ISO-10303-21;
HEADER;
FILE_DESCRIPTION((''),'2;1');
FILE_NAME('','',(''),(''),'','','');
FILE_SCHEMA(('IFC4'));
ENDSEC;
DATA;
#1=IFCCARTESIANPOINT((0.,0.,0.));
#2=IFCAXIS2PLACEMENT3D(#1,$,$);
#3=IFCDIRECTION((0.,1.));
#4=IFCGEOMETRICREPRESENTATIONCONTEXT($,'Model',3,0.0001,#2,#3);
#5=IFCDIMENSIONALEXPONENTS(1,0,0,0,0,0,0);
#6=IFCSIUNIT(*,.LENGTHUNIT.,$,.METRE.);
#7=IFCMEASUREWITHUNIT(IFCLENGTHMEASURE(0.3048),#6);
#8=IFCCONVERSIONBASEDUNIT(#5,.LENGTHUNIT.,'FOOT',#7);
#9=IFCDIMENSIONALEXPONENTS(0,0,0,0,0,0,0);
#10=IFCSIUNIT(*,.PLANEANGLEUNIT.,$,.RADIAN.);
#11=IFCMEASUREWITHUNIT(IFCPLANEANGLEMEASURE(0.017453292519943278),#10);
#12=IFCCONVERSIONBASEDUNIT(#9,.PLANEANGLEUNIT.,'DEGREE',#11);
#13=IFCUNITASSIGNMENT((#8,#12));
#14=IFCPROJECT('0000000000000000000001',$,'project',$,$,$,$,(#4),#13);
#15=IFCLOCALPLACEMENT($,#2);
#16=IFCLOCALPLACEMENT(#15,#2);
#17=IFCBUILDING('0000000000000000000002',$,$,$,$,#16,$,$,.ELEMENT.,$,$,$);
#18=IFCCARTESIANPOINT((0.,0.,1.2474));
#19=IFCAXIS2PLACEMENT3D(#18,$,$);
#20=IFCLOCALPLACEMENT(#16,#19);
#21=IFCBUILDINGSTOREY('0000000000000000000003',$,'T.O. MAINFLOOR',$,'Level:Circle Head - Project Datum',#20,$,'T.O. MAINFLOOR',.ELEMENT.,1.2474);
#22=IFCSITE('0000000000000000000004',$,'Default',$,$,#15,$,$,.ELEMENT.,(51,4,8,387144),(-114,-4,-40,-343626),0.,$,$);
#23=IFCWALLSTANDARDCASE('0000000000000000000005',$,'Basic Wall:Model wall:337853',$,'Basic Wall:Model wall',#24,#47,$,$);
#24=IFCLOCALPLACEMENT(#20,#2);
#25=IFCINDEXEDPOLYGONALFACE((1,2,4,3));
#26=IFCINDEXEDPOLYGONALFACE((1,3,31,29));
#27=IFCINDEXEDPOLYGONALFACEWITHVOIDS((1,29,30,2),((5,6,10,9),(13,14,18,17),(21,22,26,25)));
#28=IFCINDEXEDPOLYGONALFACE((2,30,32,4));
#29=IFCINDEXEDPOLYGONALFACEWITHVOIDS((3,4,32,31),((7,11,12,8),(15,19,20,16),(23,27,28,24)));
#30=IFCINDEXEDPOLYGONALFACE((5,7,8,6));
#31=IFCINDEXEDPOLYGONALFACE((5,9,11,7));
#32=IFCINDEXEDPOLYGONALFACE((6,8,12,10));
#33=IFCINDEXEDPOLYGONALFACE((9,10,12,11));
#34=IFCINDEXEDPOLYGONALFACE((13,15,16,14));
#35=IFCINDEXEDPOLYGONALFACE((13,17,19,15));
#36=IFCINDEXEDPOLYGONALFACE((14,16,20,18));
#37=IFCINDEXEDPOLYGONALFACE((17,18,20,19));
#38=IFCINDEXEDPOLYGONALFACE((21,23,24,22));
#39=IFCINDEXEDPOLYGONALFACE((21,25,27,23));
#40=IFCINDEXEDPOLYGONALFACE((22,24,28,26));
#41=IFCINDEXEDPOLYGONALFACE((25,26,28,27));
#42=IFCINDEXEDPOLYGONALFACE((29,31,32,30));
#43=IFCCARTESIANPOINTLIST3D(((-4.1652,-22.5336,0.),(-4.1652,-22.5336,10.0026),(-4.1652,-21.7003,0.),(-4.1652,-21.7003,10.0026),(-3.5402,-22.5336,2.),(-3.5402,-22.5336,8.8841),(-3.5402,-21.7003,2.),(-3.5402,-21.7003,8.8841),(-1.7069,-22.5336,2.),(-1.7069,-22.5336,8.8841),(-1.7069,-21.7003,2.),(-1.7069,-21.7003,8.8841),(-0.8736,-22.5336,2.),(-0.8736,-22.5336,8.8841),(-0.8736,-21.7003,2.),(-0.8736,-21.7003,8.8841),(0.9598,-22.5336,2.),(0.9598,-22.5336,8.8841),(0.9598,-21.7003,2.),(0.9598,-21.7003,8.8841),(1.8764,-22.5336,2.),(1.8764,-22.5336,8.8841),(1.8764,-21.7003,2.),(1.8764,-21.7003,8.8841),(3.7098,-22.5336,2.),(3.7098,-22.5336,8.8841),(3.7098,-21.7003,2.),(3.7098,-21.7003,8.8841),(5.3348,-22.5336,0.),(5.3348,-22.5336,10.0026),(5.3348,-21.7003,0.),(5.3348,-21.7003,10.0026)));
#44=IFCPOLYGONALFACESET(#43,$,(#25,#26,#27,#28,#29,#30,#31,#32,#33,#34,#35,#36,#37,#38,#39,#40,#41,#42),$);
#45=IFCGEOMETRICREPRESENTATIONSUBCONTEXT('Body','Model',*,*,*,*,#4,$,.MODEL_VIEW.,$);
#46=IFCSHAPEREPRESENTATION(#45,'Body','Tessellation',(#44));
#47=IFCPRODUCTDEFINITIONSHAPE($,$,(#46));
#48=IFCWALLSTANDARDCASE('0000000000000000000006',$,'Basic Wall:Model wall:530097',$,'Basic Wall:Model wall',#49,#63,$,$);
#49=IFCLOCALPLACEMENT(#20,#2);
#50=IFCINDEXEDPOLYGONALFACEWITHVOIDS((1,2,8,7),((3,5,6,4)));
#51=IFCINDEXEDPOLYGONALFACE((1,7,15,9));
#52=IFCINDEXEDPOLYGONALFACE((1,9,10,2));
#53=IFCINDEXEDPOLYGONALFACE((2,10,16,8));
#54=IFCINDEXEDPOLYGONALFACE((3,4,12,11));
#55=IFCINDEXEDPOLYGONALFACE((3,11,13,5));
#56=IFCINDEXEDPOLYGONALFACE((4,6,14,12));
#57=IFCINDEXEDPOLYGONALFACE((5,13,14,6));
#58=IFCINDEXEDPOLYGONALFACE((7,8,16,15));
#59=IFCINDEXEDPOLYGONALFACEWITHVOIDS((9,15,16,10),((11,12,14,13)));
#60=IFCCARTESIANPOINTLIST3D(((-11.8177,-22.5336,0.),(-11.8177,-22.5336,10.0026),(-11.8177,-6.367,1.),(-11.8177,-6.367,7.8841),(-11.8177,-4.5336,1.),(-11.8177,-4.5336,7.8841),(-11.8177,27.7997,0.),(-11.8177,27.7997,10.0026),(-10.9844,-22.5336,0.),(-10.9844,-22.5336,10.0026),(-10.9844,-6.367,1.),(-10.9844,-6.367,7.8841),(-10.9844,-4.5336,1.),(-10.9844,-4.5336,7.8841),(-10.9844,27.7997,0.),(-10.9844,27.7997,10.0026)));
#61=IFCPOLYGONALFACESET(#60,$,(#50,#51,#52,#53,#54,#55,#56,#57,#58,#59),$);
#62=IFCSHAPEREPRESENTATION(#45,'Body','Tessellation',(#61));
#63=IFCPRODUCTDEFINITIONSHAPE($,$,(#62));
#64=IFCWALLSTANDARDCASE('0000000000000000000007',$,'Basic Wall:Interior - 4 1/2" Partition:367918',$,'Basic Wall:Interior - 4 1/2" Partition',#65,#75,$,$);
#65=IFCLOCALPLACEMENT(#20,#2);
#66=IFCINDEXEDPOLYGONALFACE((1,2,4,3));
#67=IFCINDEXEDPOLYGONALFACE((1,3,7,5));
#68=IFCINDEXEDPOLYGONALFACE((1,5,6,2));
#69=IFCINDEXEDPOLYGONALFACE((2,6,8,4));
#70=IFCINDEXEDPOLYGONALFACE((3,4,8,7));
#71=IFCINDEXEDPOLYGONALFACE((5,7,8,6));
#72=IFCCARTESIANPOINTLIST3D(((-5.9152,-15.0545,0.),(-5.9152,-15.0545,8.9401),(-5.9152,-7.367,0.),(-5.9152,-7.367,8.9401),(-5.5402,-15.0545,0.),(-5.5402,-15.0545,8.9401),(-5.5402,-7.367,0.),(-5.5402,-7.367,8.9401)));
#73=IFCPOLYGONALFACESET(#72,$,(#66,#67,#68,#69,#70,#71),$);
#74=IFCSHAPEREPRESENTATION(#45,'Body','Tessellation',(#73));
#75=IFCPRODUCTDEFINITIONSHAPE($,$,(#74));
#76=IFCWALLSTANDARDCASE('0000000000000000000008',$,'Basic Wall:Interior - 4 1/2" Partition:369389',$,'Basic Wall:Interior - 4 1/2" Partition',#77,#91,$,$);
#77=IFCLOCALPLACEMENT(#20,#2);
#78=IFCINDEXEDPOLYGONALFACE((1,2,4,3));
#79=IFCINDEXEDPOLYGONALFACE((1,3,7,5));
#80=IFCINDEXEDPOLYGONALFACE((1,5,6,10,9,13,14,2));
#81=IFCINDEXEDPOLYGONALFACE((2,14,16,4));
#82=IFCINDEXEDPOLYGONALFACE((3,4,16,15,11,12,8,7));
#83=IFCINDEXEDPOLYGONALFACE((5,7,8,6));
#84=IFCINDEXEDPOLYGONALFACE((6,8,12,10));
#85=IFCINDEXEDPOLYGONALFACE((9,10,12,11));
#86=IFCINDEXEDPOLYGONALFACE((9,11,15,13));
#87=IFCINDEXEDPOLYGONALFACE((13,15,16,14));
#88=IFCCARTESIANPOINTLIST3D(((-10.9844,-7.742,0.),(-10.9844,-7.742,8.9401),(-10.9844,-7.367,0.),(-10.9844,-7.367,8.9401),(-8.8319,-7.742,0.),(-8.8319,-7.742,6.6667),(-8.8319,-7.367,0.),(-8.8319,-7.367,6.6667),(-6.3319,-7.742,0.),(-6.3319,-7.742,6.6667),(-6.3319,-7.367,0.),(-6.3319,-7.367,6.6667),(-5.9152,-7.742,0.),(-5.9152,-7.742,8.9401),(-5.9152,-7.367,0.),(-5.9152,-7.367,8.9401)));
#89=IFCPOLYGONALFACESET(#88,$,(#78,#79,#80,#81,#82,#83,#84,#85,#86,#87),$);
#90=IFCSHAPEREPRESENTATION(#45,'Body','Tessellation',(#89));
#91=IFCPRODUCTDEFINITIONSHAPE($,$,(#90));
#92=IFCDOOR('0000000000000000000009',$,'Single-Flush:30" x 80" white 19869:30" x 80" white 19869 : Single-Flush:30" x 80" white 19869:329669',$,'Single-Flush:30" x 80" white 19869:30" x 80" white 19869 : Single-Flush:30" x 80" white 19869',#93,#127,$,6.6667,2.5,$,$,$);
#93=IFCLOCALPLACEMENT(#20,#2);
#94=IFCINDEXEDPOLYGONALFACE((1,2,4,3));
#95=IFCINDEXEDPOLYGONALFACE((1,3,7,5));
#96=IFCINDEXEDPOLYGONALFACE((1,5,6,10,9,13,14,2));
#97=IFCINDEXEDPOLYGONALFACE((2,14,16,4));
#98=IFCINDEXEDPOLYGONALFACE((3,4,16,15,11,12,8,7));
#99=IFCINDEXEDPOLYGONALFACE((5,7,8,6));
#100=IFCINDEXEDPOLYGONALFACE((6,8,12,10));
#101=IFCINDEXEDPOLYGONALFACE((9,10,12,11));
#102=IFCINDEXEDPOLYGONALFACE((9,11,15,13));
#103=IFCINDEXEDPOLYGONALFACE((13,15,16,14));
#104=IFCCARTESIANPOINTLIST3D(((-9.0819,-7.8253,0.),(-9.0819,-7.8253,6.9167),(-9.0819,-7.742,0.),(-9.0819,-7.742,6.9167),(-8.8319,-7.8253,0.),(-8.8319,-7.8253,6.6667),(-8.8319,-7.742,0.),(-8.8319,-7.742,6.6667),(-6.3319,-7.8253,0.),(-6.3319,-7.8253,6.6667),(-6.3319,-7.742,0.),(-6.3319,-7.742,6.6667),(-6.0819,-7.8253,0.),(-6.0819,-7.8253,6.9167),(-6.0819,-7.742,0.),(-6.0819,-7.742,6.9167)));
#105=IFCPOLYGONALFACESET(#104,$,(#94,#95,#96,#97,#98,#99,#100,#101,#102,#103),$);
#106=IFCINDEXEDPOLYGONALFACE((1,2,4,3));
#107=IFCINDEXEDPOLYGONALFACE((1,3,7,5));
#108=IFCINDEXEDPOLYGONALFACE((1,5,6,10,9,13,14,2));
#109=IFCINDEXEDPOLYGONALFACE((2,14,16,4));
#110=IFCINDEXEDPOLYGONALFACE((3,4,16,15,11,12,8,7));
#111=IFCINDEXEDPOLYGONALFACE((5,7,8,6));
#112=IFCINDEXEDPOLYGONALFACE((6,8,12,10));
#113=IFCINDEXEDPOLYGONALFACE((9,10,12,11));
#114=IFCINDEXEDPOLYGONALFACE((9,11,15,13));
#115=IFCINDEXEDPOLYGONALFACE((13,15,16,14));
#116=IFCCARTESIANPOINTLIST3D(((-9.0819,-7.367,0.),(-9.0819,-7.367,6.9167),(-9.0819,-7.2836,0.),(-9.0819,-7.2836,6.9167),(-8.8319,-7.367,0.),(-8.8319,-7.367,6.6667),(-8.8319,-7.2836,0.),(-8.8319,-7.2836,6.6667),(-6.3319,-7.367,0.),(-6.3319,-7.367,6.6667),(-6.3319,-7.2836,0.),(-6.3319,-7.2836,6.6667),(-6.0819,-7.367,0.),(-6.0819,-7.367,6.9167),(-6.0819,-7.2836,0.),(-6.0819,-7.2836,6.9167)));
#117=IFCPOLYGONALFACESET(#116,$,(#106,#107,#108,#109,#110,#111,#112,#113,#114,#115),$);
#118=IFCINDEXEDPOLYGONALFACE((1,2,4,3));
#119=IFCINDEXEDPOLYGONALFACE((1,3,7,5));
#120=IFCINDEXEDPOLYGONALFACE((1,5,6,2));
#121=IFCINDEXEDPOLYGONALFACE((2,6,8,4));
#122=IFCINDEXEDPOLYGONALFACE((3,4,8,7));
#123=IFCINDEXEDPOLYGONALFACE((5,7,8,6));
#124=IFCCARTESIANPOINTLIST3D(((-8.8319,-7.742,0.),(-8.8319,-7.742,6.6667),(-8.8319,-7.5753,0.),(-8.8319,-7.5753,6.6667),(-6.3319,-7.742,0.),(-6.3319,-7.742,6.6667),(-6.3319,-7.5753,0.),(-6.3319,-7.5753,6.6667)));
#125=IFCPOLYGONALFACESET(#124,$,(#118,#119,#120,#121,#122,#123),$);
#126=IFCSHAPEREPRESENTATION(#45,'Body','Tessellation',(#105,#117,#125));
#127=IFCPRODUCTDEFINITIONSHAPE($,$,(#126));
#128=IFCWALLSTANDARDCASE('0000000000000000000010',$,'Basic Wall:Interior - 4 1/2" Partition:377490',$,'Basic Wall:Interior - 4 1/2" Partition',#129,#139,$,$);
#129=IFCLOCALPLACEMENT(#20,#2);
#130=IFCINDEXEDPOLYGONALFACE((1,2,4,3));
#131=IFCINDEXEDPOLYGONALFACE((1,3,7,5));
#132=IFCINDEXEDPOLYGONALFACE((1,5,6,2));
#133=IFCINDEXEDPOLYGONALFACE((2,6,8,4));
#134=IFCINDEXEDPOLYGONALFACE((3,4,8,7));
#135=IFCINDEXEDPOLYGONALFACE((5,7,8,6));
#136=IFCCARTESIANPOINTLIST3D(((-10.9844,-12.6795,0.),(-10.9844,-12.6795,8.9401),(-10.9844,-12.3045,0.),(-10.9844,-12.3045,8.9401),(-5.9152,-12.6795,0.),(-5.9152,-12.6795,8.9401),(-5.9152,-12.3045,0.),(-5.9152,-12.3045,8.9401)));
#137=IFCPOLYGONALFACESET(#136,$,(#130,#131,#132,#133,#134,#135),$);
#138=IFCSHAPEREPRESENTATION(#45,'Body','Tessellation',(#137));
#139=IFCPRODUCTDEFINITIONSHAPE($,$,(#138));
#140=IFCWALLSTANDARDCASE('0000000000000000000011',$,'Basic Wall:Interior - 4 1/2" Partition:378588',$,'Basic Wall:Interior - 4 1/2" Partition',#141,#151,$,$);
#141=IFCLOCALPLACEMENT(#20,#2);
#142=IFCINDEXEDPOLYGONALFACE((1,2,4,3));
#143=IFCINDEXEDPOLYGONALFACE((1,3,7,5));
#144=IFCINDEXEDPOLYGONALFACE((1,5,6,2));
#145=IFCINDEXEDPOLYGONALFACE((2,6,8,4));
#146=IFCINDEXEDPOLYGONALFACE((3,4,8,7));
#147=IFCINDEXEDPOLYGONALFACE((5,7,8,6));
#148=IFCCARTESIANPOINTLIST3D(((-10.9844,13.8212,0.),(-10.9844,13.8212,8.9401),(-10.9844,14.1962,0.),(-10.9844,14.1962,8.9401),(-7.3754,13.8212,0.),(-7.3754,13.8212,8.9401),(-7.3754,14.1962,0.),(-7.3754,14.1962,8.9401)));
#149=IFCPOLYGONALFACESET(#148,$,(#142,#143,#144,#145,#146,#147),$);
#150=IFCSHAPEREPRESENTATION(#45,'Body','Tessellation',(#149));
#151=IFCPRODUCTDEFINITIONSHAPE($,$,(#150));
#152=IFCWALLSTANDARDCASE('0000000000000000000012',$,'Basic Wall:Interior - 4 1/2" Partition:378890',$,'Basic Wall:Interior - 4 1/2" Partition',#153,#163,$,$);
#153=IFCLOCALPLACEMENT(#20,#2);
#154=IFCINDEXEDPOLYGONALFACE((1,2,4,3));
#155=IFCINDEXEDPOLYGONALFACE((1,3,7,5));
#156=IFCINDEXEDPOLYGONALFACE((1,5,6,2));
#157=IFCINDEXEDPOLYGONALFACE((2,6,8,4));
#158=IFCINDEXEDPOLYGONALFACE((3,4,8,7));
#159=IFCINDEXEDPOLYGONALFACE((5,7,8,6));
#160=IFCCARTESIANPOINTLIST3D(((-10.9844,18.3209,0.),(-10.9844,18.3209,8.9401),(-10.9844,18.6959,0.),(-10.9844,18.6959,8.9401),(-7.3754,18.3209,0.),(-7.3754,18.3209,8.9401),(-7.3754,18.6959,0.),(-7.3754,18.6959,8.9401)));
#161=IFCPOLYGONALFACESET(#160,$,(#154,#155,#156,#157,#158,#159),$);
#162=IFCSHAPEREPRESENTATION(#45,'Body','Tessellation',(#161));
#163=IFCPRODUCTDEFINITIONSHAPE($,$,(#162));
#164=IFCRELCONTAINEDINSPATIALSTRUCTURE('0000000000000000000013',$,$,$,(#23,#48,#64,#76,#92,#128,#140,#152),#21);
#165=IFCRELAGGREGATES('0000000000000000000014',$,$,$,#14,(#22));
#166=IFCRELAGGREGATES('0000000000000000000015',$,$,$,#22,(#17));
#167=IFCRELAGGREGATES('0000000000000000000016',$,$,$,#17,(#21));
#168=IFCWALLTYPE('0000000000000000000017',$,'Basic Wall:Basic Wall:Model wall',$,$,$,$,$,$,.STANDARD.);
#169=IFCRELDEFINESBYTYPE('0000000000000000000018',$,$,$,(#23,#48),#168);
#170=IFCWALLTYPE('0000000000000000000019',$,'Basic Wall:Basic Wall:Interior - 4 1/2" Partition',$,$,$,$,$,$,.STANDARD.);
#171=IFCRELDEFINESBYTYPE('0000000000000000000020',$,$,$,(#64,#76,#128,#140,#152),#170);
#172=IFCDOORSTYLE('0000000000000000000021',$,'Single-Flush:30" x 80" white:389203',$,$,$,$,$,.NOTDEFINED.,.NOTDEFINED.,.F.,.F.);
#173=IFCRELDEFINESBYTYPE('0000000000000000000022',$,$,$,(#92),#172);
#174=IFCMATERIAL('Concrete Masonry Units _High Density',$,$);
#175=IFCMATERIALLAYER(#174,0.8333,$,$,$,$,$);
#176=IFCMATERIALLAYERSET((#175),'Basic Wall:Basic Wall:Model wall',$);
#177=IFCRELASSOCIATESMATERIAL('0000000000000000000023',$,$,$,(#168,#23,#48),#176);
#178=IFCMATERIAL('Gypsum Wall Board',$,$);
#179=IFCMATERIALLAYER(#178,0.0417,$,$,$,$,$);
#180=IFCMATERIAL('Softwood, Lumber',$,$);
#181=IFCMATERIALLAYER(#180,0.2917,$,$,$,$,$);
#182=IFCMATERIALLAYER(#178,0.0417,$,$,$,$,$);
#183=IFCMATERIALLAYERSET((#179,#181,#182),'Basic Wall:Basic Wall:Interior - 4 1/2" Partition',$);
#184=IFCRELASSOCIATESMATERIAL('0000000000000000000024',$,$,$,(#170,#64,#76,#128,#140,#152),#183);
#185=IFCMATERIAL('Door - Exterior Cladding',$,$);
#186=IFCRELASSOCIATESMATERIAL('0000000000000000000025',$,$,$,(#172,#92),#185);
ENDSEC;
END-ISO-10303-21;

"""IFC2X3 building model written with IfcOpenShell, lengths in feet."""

from ifc_helpers import new_model, entity, si_unit, converted_unit, direction, frame, frame_2d, origin, place, context, subcontext, project, spatial, polyline, rectangle, outline, extrude, source, transform, mapped, material, layer, layer_set, layer_usage, type_object, type_shapes, element, fill, save


model = new_model("IFC2X3")

# Units and contexts
model_context = context("Model", 3, precision=0.0001, world=origin(), true_north=direction((0.0, 1.0)))
body_context = subcontext(model_context, "Body", "Model", "MODEL_VIEW")
ifc_project = project(units=[converted_unit("LENGTHUNIT", "FOOT", entity("IfcLengthMeasure", 0.3048), si_unit("LENGTHUNIT", "METRE"), dimensions=[1, 0, 0, 0, 0, 0, 0]), converted_unit("PLANEANGLEUNIT", "DEGREE", entity("IfcPlaneAngleMeasure", 0.017453292519943278), si_unit("PLANEANGLEUNIT", "RADIAN"), dimensions=[0, 0, 0, 0, 0, 0, 0])], contexts=[model_context])

# Site, building, storey
site_placement = place(None, origin())
site = spatial("IfcSite", under=ifc_project, at=site_placement, Name="Default", CompositionType="ELEMENT", RefLatitude=(51, 4, 8, 387144), RefLongitude=(-114, -4, -40, -343626), RefElevation=0.0)
building_placement = place(site_placement, origin())
building = spatial("IfcBuilding", under=site, at=building_placement, CompositionType="ELEMENT")
storey_placement = place(building_placement, frame((0.0, 0.0, 1.2474)))
storey = spatial("IfcBuildingStorey", under=building, at=storey_placement, Name="T.O. MAINFLOOR", ObjectType="Level:Circle Head - Project Datum", LongName="T.O. MAINFLOOR", CompositionType="ELEMENT", Elevation=1.2474)

# Shared definitions
ifc_material_1 = material(Name="Gypsum Wall Board")

# Shared definitions
ifc_material_2 = material(Name="Concrete Masonry Units _High Density")
ifc_layer_1 = layer(ifc_material_2, 0.8333)
ifc_layer_set_1 = layer_set([ifc_layer_1], Name="Basic Wall:Basic Wall:Model wall")
wall_type_1 = type_object("IfcWallType", Name="Basic Wall:Basic Wall:Model wall", PredefinedType="STANDARD", material=ifc_layer_set_1)

# Shared definitions
ifc_material_3 = material(Name="Door - Exterior Cladding")

# Wall, openings
ifc_layer_usage_1 = layer_usage(ifc_layer_set_1, "AXIS2", "NEGATIVE", 0.4167)
wall_1_placement = place(storey_placement, frame((-4.1652, -22.117, 0.0)))
wall_1 = element("IfcWallStandardCase", 1, at=wall_1_placement, inside=storey, type_object=wall_type_1, material=ifc_layer_usage_1, Name="Basic Wall:Model wall:337853", ObjectType="Basic Wall:Model wall", context=body_context, shape_type="SweptSolid", body=[
    extrude(rectangle(XDim=9.5, YDim=0.8333, at=frame_2d((4.75, 0.0), x_axis=(-1.0, 0.0))), origin(), (0.0, 0.0, 1.0), 10.0026),
])
opening_1_placement = place(wall_1_placement, frame((4.1652, 22.117, 0.0)))
element("IfcOpeningElement", 2, at=opening_1_placement, cuts=wall_1, ObjectType="Opening", context=body_context, shape_type="SweptSolid", body=[
    extrude(rectangle(XDim=6.8841, YDim=1.8333, at=frame_2d((0.0, 0.0), x_axis=(1.0, 0.0))), frame((2.7931, -22.542, 5.4421), z_axis=(0.0, 1.0, 0.0), x_axis=(0.0, 0.0, 1.0)), (0.0, 0.0, 1.0), 0.85),
])
opening_2_placement = place(wall_1_placement, frame((4.1652, 22.117, 0.0)))
element("IfcOpeningElement", 3, at=opening_2_placement, cuts=wall_1, ObjectType="Opening", context=body_context, shape_type="SweptSolid", body=[
    extrude(rectangle(XDim=6.8841, YDim=1.8333, at=frame_2d((0.0, 0.0), x_axis=(1.0, 0.0))), frame((0.0431, -22.542, 5.4421), z_axis=(0.0, 1.0, 0.0), x_axis=(0.0, 0.0, 1.0)), (0.0, 0.0, 1.0), 0.85),
])
opening_3_placement = place(wall_1_placement, frame((4.1652, 22.117, 0.0)))
element("IfcOpeningElement", 4, at=opening_3_placement, cuts=wall_1, ObjectType="Opening", context=body_context, shape_type="SweptSolid", body=[
    extrude(rectangle(XDim=6.8841, YDim=1.8333, at=frame_2d((0.0, 0.0), x_axis=(1.0, 0.0))), frame((-2.6236, -22.542, 5.4421), z_axis=(0.0, 1.0, 0.0), x_axis=(0.0, 0.0, 1.0)), (0.0, 0.0, 1.0), 0.85),
])

# Wall, opening
ifc_layer_usage_2 = layer_usage(ifc_layer_set_1, "AXIS2", "NEGATIVE", 0.4167)
wall_2_placement = place(storey_placement, frame((-11.401, 27.7997, 0.0), z_axis=(0.0, 0.0, 1.0), x_axis=(0.0, -1.0, 0.0)))
wall_2 = element("IfcWallStandardCase", 5, at=wall_2_placement, inside=storey, type_object=wall_type_1, material=ifc_layer_usage_2, Name="Basic Wall:Model wall:530097", ObjectType="Basic Wall:Model wall", context=body_context, shape_type="SweptSolid", body=[
    extrude(rectangle(XDim=50.3333, YDim=0.8333, at=frame_2d((25.1667, 0.0), x_axis=(-1.0, 0.0))), origin(), (0.0, 0.0, 1.0), 10.0026),
])
opening_4_placement = place(wall_2_placement, frame((27.7997, 11.401, 0.0), z_axis=(0.0, 0.0, 1.0), x_axis=(0.0, 1.0, 0.0)))
element("IfcOpeningElement", 6, at=opening_4_placement, cuts=wall_2, ObjectType="Opening", context=body_context, shape_type="SweptSolid", body=[
    extrude(rectangle(XDim=6.8841, YDim=1.8333, at=frame_2d((0.0, 0.0), x_axis=(1.0, 0.0))), frame((-11.826, -5.4503, 4.4421), z_axis=(1.0, 0.0, 0.0), x_axis=(0.0, 0.0, 1.0)), (0.0, 0.0, 1.0), 0.85),
])

# Wall
ifc_layer_2 = layer(ifc_material_1, 0.0417)
ifc_material_4 = material(Name="Softwood, Lumber")
ifc_layer_3 = layer(ifc_material_4, 0.2917)
ifc_layer_4 = layer(ifc_material_1, 0.0417)
ifc_layer_set_2 = layer_set([ifc_layer_2, ifc_layer_3, ifc_layer_4], Name="Basic Wall:Basic Wall:Interior - 4 1/2\" Partition")
ifc_layer_usage_3 = layer_usage(ifc_layer_set_2, "AXIS2", "NEGATIVE", 0.1875)
wall_type_2 = type_object("IfcWallType", Name="Basic Wall:Basic Wall:Interior - 4 1/2\" Partition", PredefinedType="STANDARD", material=ifc_layer_set_2)
wall_3_placement = place(storey_placement, frame((-5.7277, -15.0545, 0.0), z_axis=(0.0, 0.0, 1.0), x_axis=(0.0, 1.0, 0.0)))
element("IfcWallStandardCase", 7, at=wall_3_placement, inside=storey, type_object=wall_type_2, material=ifc_layer_usage_3, Name="Basic Wall:Interior - 4 1/2\" Partition:367918", ObjectType="Basic Wall:Interior - 4 1/2\" Partition", context=body_context, shape_type="SweptSolid", body=[
    extrude(rectangle(XDim=7.6875, YDim=0.375, at=frame_2d((3.8438, 0.0), x_axis=(-1.0, 0.0))), origin(), (0.0, 0.0, 1.0), 8.9401),
])

# Wall, opening, door
ifc_layer_usage_4 = layer_usage(ifc_layer_set_2, "AXIS2", "NEGATIVE", 0.1875)
wall_4_placement = place(storey_placement, frame((-10.9844, -7.5545, 0.0)))
wall_4 = element("IfcWallStandardCase", 8, at=wall_4_placement, inside=storey, type_object=wall_type_2, material=ifc_layer_usage_4, Name="Basic Wall:Interior - 4 1/2\" Partition:369389", ObjectType="Basic Wall:Interior - 4 1/2\" Partition", context=body_context, shape_type="SweptSolid", body=[
    extrude(rectangle(XDim=5.0692, YDim=0.375, at=frame_2d((2.5346, 0.0), x_axis=(1.0, 0.0))), origin(), (0.0, 0.0, 1.0), 8.9401),
])
opening_5_placement = place(wall_4_placement, frame((10.9844, 7.5545, 0.0)))
opening_5 = element("IfcOpeningElement", 9, at=opening_5_placement, cuts=wall_4, ObjectType="Opening", context=body_context, shape_type="SweptSolid", body=[
    extrude(rectangle(XDim=6.6667, YDim=2.5, at=frame_2d((0.0, 0.0), x_axis=(0.0, 1.0))), frame((-7.5819, -7.7457, 3.3333), z_axis=(0.0, 1.0, 0.0), x_axis=(-1.0, 0.0, 0.0)), (0.0, 0.0, 1.0), 0.3825),
])
door_style_1 = type_object("IfcDoorStyle", Name="Single-Flush:30\" x 80\" white:389203", ConstructionType="NOTDEFINED", OperationType="NOTDEFINED", ParameterTakesPrecedence=False, Sizeable=False, material=ifc_material_3)
shared_shape_1 = source(origin(), body_context, "Body", "SweptSolid", [
    extrude(outline(polyline([(-1.5, -3.5208), (1.5, -3.5208), (1.5, 3.3958), (1.25, 3.3958), (1.25, -3.2708), (-1.25, -3.2708), (-1.25, 3.3958), (-1.5, 3.3958), (-1.5, -3.5208)])), frame((1.25, 0.3787, 3.3958), z_axis=(0.0, 1.0, 0.0), x_axis=(1.0, 0.0, 0.0)), (0.0, 0.0, 1.0), 0.0833),
    extrude(outline(polyline([(-3.3958, -1.5), (3.5208, -1.5), (3.5208, 1.5), (-3.3958, 1.5), (-3.3958, 1.25), (3.2708, 1.25), (3.2708, -1.25), (-3.3958, -1.25), (-3.3958, -1.5)])), frame((1.25, -0.0796, 3.3958), z_axis=(0.0, 1.0, 0.0), x_axis=(0.0, 0.0, 1.0)), (0.0, 0.0, 1.0), 0.0833),
    extrude(rectangle(XDim=0.1667, YDim=2.5, at=frame_2d((0.0, 0.0), x_axis=(1.0, 0.0))), frame((1.25, 0.2954, 0.0), z_axis=(0.0, 0.0, 1.0), x_axis=(0.0, 1.0, 0.0)), (0.0, 0.0, 1.0), 6.6667),
])
type_shapes(door_style_1, [shared_shape_1])
door_1_placement = place(opening_5_placement, frame((-6.3319, -7.3632, 0.0), z_axis=(0.0, 0.0, 1.0), x_axis=(-1.0, 0.0, 0.0)))
door_1 = element("IfcDoor", 10, at=door_1_placement, inside=storey, type_object=door_style_1, material=ifc_material_3, Name="Single-Flush:30\" x 80\" white 19869:30\" x 80\" white 19869 : Single-Flush:30\" x 80\" white 19869:329669", ObjectType="Single-Flush:30\" x 80\" white 19869:30\" x 80\" white 19869 : Single-Flush:30\" x 80\" white 19869", OverallHeight=6.6667, OverallWidth=2.5, context=body_context, shape_type="MappedRepresentation", body=[
    mapped(shared_shape_1, transform((0.0, 0.0, 0.0), scale=1.0)),
])
fill(opening_5, door_1)

# Walls
ifc_layer_usage_5 = layer_usage(ifc_layer_set_2, "AXIS2", "NEGATIVE", 0.1875)
wall_5_placement = place(storey_placement, frame((-10.9844, -12.492, 0.0)))
element("IfcWallStandardCase", 11, at=wall_5_placement, inside=storey, type_object=wall_type_2, material=ifc_layer_usage_5, Name="Basic Wall:Interior - 4 1/2\" Partition:377490", ObjectType="Basic Wall:Interior - 4 1/2\" Partition", context=body_context, shape_type="SweptSolid", body=[
    extrude(rectangle(XDim=5.0692, YDim=0.375, at=frame_2d((2.5346, 0.0), x_axis=(-1.0, 0.0))), origin(), (0.0, 0.0, 1.0), 8.9401),
])
ifc_layer_usage_6 = layer_usage(ifc_layer_set_2, "AXIS2", "NEGATIVE", 0.1875)
wall_6_placement = place(storey_placement, frame((-10.9844, 14.0087, 0.0)))
element("IfcWallStandardCase", 12, at=wall_6_placement, inside=storey, type_object=wall_type_2, material=ifc_layer_usage_6, Name="Basic Wall:Interior - 4 1/2\" Partition:378588", ObjectType="Basic Wall:Interior - 4 1/2\" Partition", context=body_context, shape_type="SweptSolid", body=[
    extrude(rectangle(XDim=3.609, YDim=0.375, at=frame_2d((1.8045, 0.0), x_axis=(-1.0, 0.0))), origin(), (0.0, 0.0, 1.0), 8.9401),
])
ifc_layer_usage_7 = layer_usage(ifc_layer_set_2, "AXIS2", "NEGATIVE", 0.1875)
wall_7_placement = place(storey_placement, frame((-10.9844, 18.5084, 0.0)))
element("IfcWallStandardCase", 13, at=wall_7_placement, inside=storey, type_object=wall_type_2, material=ifc_layer_usage_7, Name="Basic Wall:Interior - 4 1/2\" Partition:378890", ObjectType="Basic Wall:Interior - 4 1/2\" Partition", context=body_context, shape_type="SweptSolid", body=[
    extrude(rectangle(XDim=3.609, YDim=0.375, at=frame_2d((1.8045, 0.0), x_axis=(-1.0, 0.0))), origin(), (0.0, 0.0, 1.0), 8.9401),
])

save(model, "model.ifc")
